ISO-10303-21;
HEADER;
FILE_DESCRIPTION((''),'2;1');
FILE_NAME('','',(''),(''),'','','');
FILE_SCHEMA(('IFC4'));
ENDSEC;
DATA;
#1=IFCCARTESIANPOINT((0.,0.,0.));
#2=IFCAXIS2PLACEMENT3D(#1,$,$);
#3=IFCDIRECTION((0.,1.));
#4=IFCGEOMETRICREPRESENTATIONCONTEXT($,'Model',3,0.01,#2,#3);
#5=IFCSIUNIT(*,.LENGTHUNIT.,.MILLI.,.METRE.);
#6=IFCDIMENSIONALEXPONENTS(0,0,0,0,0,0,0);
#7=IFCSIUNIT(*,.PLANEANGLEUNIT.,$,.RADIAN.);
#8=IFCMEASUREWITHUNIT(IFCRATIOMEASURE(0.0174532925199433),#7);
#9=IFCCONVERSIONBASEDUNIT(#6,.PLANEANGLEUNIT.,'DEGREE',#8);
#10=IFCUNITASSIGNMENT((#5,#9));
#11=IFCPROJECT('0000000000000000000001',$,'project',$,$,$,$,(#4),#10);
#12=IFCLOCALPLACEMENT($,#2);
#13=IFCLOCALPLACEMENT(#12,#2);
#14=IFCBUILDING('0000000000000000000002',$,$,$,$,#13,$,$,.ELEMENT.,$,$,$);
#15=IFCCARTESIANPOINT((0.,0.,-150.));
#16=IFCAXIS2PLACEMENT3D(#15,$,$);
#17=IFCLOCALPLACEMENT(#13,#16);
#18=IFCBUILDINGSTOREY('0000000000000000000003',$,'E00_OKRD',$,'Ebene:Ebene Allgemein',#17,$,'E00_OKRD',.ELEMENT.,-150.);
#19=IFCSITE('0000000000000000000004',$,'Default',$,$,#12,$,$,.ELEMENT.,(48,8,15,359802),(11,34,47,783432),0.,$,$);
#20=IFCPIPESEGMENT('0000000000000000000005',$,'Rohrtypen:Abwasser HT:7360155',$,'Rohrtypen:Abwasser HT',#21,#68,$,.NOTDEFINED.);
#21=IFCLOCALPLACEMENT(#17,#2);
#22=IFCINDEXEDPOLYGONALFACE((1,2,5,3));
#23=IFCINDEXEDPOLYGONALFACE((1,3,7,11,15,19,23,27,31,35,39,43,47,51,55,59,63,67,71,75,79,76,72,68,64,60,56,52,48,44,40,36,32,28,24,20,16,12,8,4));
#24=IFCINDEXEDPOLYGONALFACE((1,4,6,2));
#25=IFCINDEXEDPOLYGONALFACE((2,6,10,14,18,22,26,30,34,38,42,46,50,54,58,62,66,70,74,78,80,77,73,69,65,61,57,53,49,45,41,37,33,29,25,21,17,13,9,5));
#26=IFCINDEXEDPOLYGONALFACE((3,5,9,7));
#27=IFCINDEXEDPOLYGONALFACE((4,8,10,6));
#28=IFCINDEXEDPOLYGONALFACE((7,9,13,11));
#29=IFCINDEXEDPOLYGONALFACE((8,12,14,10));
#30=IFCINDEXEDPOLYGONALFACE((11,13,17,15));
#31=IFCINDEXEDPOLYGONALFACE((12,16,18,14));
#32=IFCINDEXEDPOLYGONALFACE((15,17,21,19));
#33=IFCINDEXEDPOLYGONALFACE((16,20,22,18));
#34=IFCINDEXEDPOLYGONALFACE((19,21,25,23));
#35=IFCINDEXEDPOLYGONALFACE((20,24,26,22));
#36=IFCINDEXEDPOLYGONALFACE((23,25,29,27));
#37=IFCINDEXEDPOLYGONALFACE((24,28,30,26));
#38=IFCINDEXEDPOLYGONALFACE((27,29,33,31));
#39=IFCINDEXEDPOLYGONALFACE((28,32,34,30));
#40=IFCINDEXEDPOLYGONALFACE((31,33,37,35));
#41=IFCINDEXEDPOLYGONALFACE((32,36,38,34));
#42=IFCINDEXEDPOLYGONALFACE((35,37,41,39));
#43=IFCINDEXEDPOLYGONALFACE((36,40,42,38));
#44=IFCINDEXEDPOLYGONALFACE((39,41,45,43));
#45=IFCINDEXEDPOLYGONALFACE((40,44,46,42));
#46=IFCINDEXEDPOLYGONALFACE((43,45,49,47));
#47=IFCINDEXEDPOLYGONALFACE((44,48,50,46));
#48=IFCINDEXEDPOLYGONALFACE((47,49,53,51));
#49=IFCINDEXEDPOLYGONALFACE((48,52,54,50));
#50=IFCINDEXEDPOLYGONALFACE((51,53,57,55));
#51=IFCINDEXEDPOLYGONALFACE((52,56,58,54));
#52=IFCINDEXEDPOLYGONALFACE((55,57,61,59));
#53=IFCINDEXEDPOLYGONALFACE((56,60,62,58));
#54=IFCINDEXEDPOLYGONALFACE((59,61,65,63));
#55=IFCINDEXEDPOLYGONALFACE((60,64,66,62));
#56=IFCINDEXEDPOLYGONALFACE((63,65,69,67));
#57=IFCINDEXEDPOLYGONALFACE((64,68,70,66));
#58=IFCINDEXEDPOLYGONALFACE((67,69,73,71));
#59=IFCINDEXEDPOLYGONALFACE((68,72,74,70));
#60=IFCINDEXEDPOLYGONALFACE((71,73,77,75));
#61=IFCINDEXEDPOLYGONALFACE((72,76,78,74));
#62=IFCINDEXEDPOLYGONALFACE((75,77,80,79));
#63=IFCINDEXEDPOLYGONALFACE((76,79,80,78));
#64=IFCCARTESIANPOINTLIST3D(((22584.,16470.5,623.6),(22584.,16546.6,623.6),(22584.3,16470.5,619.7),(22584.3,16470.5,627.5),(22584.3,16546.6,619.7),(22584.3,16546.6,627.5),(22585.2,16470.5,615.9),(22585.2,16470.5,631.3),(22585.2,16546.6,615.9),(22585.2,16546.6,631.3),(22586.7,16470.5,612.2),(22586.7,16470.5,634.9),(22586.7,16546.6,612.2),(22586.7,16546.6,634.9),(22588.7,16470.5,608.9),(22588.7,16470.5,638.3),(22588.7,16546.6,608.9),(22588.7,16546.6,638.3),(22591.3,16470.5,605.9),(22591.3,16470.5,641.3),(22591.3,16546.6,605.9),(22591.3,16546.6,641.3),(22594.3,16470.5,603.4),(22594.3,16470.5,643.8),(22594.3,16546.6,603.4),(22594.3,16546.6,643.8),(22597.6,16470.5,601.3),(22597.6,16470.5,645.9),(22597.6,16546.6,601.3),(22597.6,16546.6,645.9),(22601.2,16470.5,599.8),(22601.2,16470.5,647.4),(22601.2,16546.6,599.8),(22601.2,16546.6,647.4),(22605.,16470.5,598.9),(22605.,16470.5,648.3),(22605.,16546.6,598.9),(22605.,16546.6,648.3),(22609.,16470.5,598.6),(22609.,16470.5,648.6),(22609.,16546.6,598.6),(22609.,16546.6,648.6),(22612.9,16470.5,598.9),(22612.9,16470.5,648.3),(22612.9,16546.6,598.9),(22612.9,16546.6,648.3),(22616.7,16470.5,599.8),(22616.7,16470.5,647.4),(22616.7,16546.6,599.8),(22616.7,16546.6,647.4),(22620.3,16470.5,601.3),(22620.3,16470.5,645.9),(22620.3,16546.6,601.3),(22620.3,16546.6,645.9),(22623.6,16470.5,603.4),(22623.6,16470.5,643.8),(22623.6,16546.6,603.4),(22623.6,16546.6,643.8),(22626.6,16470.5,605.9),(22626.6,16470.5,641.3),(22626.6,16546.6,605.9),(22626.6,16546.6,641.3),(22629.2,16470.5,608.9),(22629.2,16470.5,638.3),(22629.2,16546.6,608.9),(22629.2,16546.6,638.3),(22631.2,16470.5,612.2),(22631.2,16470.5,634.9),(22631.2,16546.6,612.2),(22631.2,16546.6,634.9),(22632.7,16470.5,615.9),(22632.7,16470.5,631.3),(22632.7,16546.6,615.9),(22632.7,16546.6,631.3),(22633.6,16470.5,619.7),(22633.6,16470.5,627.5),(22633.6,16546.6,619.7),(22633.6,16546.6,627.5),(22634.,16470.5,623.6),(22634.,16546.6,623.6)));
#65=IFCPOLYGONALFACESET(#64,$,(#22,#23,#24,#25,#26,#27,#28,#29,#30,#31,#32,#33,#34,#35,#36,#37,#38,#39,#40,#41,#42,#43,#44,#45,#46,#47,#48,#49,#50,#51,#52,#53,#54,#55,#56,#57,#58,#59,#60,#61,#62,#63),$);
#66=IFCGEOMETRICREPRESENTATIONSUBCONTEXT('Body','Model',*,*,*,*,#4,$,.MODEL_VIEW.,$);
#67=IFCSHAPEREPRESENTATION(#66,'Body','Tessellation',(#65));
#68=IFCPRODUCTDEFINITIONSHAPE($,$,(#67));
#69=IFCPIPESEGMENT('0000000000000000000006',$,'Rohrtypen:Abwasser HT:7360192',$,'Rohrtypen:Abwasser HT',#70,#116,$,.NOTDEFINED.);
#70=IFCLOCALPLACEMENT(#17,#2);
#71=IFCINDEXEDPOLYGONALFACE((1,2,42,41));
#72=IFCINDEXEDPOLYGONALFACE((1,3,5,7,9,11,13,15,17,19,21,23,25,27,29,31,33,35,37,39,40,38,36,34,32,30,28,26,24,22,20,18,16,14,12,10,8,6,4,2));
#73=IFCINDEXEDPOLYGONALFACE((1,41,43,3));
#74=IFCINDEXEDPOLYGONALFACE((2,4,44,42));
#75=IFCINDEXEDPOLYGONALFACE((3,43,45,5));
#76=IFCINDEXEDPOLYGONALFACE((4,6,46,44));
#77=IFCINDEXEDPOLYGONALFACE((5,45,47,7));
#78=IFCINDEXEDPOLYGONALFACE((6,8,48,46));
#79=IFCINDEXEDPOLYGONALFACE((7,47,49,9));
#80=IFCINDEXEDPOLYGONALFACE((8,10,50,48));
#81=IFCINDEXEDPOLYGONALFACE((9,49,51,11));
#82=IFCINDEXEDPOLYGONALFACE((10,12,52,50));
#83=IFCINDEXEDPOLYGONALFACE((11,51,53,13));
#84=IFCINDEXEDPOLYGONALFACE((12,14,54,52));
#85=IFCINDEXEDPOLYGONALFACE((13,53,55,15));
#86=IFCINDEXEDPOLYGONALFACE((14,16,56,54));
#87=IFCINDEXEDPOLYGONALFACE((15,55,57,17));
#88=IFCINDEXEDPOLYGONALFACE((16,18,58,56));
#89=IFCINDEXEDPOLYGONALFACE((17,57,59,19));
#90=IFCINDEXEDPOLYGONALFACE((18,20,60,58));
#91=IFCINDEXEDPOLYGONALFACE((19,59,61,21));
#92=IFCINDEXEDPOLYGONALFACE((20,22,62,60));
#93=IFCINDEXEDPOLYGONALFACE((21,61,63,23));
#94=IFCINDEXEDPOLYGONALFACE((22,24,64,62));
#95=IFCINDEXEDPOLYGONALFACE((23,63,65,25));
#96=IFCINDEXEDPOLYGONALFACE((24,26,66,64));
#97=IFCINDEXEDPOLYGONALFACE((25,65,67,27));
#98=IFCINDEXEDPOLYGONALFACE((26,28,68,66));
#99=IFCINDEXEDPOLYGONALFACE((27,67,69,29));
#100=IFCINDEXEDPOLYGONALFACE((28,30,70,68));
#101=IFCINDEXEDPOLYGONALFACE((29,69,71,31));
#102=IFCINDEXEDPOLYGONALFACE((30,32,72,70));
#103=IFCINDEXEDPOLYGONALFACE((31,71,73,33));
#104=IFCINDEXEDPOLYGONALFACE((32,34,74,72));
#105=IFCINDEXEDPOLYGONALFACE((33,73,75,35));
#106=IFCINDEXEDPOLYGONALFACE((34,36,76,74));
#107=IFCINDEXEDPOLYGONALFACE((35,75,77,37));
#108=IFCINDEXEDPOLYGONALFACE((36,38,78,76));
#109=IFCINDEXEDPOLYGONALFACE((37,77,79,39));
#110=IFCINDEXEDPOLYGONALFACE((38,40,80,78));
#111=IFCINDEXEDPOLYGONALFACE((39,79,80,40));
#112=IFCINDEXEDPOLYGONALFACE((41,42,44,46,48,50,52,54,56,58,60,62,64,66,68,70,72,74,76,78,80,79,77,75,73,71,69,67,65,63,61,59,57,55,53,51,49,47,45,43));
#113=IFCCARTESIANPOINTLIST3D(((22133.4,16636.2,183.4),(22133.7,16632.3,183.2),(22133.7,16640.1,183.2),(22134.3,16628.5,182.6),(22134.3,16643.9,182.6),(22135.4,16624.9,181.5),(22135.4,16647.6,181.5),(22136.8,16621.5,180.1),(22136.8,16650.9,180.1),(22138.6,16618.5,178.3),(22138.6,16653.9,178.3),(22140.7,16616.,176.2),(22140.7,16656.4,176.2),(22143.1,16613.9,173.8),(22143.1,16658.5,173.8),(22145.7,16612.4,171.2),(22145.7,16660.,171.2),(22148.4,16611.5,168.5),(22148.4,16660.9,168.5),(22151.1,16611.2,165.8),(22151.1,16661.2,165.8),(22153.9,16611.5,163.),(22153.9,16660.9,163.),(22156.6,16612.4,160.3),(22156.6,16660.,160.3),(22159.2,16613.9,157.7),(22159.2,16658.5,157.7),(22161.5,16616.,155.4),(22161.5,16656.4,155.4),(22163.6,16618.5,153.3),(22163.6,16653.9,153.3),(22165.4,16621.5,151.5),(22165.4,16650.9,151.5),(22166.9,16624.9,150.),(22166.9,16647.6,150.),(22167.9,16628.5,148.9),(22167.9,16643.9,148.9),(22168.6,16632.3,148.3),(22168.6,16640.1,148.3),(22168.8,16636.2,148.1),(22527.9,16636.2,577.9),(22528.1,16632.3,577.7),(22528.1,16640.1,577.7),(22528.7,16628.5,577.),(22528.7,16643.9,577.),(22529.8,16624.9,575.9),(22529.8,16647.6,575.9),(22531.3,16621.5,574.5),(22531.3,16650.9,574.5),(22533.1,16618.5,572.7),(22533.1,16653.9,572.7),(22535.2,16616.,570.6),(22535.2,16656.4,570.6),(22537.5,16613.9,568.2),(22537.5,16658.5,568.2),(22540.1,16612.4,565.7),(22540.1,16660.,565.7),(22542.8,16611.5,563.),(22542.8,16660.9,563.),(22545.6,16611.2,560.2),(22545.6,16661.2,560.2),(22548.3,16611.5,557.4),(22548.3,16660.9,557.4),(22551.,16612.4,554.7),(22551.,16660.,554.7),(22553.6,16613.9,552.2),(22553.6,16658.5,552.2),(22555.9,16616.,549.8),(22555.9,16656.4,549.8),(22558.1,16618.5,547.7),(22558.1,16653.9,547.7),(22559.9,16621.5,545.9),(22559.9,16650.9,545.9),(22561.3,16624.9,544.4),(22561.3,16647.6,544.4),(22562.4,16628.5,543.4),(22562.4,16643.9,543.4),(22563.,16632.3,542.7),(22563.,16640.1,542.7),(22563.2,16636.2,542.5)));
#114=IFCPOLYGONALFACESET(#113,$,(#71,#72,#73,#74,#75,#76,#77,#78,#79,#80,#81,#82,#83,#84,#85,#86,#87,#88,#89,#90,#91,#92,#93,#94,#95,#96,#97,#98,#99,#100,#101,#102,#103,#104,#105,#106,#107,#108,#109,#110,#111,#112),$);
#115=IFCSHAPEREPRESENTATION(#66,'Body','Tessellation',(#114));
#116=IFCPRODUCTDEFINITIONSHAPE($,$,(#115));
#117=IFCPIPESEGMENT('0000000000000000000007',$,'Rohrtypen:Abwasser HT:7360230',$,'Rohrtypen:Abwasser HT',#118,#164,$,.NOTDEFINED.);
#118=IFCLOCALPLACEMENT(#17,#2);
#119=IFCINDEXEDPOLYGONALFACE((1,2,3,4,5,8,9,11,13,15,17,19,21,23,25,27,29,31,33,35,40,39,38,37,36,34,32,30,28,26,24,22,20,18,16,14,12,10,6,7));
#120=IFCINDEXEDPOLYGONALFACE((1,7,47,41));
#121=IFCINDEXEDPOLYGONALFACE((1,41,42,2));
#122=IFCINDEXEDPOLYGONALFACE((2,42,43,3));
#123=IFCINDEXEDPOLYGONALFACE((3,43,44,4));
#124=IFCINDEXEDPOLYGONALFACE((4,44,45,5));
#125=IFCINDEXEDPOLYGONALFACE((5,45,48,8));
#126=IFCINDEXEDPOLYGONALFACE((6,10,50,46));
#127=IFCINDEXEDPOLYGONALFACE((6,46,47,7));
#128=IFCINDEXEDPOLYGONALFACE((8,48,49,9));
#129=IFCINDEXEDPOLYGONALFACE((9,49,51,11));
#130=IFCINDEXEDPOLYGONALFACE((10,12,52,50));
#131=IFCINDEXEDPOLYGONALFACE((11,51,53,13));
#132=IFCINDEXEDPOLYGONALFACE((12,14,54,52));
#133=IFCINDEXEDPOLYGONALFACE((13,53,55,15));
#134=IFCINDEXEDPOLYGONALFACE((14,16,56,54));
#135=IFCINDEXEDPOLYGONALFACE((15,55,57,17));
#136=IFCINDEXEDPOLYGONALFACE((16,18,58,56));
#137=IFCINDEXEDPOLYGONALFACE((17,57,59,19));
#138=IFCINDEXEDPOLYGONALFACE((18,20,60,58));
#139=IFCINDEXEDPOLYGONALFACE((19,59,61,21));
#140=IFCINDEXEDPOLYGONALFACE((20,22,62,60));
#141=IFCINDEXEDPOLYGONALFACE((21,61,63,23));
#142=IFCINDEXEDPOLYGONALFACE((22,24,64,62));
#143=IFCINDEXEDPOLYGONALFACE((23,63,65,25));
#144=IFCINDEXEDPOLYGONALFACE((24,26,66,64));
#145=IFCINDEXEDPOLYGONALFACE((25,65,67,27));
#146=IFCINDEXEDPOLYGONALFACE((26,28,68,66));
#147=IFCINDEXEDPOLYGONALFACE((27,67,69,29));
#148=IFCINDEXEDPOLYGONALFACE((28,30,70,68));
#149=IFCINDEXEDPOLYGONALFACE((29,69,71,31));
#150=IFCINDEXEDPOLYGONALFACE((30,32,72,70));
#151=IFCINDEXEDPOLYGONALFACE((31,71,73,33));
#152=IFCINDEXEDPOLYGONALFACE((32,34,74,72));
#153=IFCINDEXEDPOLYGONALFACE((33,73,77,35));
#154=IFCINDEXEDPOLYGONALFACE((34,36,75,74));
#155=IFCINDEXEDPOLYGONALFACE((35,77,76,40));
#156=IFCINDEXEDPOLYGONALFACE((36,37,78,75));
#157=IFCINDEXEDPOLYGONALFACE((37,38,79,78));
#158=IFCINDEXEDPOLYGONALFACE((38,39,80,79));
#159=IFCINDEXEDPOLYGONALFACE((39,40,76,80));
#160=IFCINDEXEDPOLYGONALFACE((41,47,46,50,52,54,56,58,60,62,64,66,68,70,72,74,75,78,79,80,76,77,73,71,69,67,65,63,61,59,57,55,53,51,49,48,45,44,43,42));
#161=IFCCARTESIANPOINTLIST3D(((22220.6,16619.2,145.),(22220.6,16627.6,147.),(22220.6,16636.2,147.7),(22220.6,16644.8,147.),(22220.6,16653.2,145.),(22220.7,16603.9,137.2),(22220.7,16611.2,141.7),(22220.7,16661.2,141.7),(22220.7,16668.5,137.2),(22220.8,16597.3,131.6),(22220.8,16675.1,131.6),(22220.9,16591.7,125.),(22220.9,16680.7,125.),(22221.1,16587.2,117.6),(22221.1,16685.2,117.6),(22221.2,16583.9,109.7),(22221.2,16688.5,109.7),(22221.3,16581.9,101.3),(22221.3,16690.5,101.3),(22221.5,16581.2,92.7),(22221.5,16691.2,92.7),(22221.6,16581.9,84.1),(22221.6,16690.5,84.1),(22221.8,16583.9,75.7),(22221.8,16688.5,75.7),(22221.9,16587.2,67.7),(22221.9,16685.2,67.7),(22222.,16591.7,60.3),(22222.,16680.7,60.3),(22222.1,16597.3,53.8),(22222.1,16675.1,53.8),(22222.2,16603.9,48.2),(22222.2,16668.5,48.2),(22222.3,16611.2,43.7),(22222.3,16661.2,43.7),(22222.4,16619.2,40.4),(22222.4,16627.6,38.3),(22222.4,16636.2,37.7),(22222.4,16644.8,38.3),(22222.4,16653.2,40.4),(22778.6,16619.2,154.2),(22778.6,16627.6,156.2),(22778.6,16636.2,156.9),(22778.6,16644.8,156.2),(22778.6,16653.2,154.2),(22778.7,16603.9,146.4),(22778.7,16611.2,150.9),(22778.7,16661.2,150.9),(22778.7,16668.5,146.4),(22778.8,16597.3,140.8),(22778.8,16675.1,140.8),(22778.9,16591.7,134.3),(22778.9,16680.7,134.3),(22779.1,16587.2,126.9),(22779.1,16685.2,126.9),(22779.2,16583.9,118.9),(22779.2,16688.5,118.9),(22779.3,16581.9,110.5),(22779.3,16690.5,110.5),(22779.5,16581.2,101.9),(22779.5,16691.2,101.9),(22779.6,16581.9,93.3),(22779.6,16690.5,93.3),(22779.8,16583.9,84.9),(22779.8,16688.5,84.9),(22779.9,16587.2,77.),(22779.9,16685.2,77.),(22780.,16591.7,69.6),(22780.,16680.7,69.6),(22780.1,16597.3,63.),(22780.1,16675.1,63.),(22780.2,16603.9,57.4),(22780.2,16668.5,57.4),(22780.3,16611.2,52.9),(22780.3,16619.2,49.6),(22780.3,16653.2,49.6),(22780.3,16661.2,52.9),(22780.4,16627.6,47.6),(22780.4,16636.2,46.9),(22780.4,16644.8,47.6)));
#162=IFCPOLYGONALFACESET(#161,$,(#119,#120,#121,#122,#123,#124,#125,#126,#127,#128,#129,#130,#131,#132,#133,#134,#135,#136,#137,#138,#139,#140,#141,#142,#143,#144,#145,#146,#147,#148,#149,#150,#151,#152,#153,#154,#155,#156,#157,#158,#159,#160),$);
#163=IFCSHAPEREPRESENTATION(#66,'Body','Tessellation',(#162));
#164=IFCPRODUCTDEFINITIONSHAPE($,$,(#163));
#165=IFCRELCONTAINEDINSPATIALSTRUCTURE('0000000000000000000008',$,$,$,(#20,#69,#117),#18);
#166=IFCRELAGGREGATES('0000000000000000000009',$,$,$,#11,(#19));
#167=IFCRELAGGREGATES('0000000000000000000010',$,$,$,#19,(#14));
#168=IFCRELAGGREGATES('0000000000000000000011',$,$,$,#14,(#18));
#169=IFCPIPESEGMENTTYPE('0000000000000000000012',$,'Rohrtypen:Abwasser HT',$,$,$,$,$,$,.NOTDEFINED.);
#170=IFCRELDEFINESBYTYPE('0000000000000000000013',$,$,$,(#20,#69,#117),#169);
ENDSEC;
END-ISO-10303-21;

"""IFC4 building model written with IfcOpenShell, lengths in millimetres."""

from ifc_helpers import new_model, entity, si_unit, converted_unit, direction, frame, origin, place, context, subcontext, project, spatial, indexed_curve, outline, extrude, type_object, element, save


model = new_model("IFC4")

# Units and contexts
model_context = context("Model", 3, precision=0.01, world=origin(), true_north=direction((0.0, 1.0)))
body_context = subcontext(model_context, "Body", "Model", "MODEL_VIEW")
ifc_project = project(units=[si_unit("LENGTHUNIT", "METRE", prefix="MILLI"), converted_unit("PLANEANGLEUNIT", "DEGREE", entity("IfcRatioMeasure", 0.0174532925199433), si_unit("PLANEANGLEUNIT", "RADIAN"), dimensions=[0, 0, 0, 0, 0, 0, 0])], contexts=[model_context])

# Site, building, storey
site_placement = place(None, origin())
site = spatial("IfcSite", under=ifc_project, at=site_placement, Name="Default", CompositionType="ELEMENT", RefLatitude=(48, 8, 15, 359802), RefLongitude=(11, 34, 47, 783432), RefElevation=0.0)
building_placement = place(site_placement, origin())
building = spatial("IfcBuilding", under=site, at=building_placement, CompositionType="ELEMENT")
storey_placement = place(building_placement, frame((0.0, 0.0, -150.0)))
storey = spatial("IfcBuildingStorey", under=building, at=storey_placement, Name="E00_OKRD", ObjectType="Ebene:Ebene Allgemein", LongName="E00_OKRD", CompositionType="ELEMENT", Elevation=-150.0)

# Pipe segments
pipe_segment_type_1 = type_object("IfcPipeSegmentType", Name="Rohrtypen:Abwasser HT", PredefinedType="NOTDEFINED")
pipe_segment_1_placement = place(storey_placement, origin())
element("IfcPipeSegment", 1, at=pipe_segment_1_placement, inside=storey, type_object=pipe_segment_type_1, Name="Rohrtypen:Abwasser HT:7360155", ObjectType="Rohrtypen:Abwasser HT", PredefinedType="NOTDEFINED", context=body_context, shape_type="SweptSolid", body=[
    extrude(outline(indexed_curve([(25.0, 0.0), (24.7, 3.9), (23.8, 7.7), (22.3, 11.3), (20.2, 14.7), (17.7, 17.7), (14.7, 20.2), (11.3, 22.3), (7.7, 23.8), (3.9, 24.7), (0.0, 25.0), (-3.9, 24.7), (-7.7, 23.8), (-11.3, 22.3), (-14.7, 20.2), (-17.7, 17.7), (-20.2, 14.7), (-22.3, 11.3), (-23.8, 7.7), (-24.7, 3.9), (-25.0, 0.0), (-24.7, -3.9), (-23.8, -7.7), (-22.3, -11.3), (-20.2, -14.7), (-17.7, -17.7), (-14.7, -20.2), (-11.3, -22.3), (-7.7, -23.8), (-3.9, -24.7), (0.0, -25.0), (3.9, -24.7), (7.7, -23.8), (11.3, -22.3), (14.7, -20.2), (17.7, -17.7), (20.2, -14.7), (22.3, -11.3), (23.8, -7.7), (24.7, -3.9), (25.0, 0.0)], self_intersect=False)), frame((22609.0, 16470.5, 623.6), z_axis=(0.0, 1.0, 0.0), x_axis=(1.0, 0.0, 0.0)), (0.0, 0.0, 1.0), 76.0),
])
pipe_segment_2_placement = place(storey_placement, origin())
element("IfcPipeSegment", 2, at=pipe_segment_2_placement, inside=storey, type_object=pipe_segment_type_1, Name="Rohrtypen:Abwasser HT:7360192", ObjectType="Rohrtypen:Abwasser HT", PredefinedType="NOTDEFINED", context=body_context, shape_type="SweptSolid", body=[
    extrude(outline(indexed_curve([(25.0, 0.0), (24.7, 3.9), (23.8, 7.7), (22.3, 11.3), (20.2, 14.7), (17.7, 17.7), (14.7, 20.2), (11.3, 22.3), (7.7, 23.8), (3.9, 24.7), (0.0, 25.0), (-3.9, 24.7), (-7.7, 23.8), (-11.3, 22.3), (-14.7, 20.2), (-17.7, 17.7), (-20.2, 14.7), (-22.3, 11.3), (-23.8, 7.7), (-24.7, 3.9), (-25.0, 0.0), (-24.7, -3.9), (-23.8, -7.7), (-22.3, -11.3), (-20.2, -14.7), (-17.7, -17.7), (-14.7, -20.2), (-11.3, -22.3), (-7.7, -23.8), (-3.9, -24.7), (0.0, -25.0), (3.9, -24.7), (7.7, -23.8), (11.3, -22.3), (14.7, -20.2), (17.7, -17.7), (20.2, -14.7), (22.3, -11.3), (23.8, -7.7), (24.7, -3.9), (25.0, 0.0)], self_intersect=False)), frame((22151.1, 16636.2, 165.8), z_axis=(0.707107, 0.0, 0.707107), x_axis=(0.0, 1.0, 0.0)), (0.0, 0.0, 1.0), 557.8),
])
pipe_segment_3_placement = place(storey_placement, origin())
element("IfcPipeSegment", 3, at=pipe_segment_3_placement, inside=storey, type_object=pipe_segment_type_1, Name="Rohrtypen:Abwasser HT:7360230", ObjectType="Rohrtypen:Abwasser HT", PredefinedType="NOTDEFINED", context=body_context, shape_type="SweptSolid", body=[
    extrude(outline(indexed_curve([(55.0, 0.0), (54.3, 8.6), (52.3, 17.0), (49.0, 25.0), (44.5, 32.3), (38.9, 38.9), (32.3, 44.5), (25.0, 49.0), (17.0, 52.3), (8.6, 54.3), (0.0, 55.0), (-8.6, 54.3), (-17.0, 52.3), (-25.0, 49.0), (-32.3, 44.5), (-38.9, 38.9), (-44.5, 32.3), (-49.0, 25.0), (-52.3, 17.0), (-54.3, 8.6), (-55.0, 0.0), (-54.3, -8.6), (-52.3, -17.0), (-49.0, -25.0), (-44.5, -32.3), (-38.9, -38.9), (-32.3, -44.5), (-25.0, -49.0), (-17.0, -52.3), (-8.6, -54.3), (0.0, -55.0), (8.6, -54.3), (17.0, -52.3), (25.0, -49.0), (32.3, -44.5), (38.9, -38.9), (44.5, -32.3), (49.0, -25.0), (52.3, -17.0), (54.3, -8.6), (55.0, 0.0)], self_intersect=False)), frame((22221.5, 16636.2, 92.7), z_axis=(0.999862, 0.0, 0.016604), x_axis=(0.0, 1.0, 0.0)), (0.0, 0.0, 1.0), 558.1),
])

save(model, "model.ifc")
